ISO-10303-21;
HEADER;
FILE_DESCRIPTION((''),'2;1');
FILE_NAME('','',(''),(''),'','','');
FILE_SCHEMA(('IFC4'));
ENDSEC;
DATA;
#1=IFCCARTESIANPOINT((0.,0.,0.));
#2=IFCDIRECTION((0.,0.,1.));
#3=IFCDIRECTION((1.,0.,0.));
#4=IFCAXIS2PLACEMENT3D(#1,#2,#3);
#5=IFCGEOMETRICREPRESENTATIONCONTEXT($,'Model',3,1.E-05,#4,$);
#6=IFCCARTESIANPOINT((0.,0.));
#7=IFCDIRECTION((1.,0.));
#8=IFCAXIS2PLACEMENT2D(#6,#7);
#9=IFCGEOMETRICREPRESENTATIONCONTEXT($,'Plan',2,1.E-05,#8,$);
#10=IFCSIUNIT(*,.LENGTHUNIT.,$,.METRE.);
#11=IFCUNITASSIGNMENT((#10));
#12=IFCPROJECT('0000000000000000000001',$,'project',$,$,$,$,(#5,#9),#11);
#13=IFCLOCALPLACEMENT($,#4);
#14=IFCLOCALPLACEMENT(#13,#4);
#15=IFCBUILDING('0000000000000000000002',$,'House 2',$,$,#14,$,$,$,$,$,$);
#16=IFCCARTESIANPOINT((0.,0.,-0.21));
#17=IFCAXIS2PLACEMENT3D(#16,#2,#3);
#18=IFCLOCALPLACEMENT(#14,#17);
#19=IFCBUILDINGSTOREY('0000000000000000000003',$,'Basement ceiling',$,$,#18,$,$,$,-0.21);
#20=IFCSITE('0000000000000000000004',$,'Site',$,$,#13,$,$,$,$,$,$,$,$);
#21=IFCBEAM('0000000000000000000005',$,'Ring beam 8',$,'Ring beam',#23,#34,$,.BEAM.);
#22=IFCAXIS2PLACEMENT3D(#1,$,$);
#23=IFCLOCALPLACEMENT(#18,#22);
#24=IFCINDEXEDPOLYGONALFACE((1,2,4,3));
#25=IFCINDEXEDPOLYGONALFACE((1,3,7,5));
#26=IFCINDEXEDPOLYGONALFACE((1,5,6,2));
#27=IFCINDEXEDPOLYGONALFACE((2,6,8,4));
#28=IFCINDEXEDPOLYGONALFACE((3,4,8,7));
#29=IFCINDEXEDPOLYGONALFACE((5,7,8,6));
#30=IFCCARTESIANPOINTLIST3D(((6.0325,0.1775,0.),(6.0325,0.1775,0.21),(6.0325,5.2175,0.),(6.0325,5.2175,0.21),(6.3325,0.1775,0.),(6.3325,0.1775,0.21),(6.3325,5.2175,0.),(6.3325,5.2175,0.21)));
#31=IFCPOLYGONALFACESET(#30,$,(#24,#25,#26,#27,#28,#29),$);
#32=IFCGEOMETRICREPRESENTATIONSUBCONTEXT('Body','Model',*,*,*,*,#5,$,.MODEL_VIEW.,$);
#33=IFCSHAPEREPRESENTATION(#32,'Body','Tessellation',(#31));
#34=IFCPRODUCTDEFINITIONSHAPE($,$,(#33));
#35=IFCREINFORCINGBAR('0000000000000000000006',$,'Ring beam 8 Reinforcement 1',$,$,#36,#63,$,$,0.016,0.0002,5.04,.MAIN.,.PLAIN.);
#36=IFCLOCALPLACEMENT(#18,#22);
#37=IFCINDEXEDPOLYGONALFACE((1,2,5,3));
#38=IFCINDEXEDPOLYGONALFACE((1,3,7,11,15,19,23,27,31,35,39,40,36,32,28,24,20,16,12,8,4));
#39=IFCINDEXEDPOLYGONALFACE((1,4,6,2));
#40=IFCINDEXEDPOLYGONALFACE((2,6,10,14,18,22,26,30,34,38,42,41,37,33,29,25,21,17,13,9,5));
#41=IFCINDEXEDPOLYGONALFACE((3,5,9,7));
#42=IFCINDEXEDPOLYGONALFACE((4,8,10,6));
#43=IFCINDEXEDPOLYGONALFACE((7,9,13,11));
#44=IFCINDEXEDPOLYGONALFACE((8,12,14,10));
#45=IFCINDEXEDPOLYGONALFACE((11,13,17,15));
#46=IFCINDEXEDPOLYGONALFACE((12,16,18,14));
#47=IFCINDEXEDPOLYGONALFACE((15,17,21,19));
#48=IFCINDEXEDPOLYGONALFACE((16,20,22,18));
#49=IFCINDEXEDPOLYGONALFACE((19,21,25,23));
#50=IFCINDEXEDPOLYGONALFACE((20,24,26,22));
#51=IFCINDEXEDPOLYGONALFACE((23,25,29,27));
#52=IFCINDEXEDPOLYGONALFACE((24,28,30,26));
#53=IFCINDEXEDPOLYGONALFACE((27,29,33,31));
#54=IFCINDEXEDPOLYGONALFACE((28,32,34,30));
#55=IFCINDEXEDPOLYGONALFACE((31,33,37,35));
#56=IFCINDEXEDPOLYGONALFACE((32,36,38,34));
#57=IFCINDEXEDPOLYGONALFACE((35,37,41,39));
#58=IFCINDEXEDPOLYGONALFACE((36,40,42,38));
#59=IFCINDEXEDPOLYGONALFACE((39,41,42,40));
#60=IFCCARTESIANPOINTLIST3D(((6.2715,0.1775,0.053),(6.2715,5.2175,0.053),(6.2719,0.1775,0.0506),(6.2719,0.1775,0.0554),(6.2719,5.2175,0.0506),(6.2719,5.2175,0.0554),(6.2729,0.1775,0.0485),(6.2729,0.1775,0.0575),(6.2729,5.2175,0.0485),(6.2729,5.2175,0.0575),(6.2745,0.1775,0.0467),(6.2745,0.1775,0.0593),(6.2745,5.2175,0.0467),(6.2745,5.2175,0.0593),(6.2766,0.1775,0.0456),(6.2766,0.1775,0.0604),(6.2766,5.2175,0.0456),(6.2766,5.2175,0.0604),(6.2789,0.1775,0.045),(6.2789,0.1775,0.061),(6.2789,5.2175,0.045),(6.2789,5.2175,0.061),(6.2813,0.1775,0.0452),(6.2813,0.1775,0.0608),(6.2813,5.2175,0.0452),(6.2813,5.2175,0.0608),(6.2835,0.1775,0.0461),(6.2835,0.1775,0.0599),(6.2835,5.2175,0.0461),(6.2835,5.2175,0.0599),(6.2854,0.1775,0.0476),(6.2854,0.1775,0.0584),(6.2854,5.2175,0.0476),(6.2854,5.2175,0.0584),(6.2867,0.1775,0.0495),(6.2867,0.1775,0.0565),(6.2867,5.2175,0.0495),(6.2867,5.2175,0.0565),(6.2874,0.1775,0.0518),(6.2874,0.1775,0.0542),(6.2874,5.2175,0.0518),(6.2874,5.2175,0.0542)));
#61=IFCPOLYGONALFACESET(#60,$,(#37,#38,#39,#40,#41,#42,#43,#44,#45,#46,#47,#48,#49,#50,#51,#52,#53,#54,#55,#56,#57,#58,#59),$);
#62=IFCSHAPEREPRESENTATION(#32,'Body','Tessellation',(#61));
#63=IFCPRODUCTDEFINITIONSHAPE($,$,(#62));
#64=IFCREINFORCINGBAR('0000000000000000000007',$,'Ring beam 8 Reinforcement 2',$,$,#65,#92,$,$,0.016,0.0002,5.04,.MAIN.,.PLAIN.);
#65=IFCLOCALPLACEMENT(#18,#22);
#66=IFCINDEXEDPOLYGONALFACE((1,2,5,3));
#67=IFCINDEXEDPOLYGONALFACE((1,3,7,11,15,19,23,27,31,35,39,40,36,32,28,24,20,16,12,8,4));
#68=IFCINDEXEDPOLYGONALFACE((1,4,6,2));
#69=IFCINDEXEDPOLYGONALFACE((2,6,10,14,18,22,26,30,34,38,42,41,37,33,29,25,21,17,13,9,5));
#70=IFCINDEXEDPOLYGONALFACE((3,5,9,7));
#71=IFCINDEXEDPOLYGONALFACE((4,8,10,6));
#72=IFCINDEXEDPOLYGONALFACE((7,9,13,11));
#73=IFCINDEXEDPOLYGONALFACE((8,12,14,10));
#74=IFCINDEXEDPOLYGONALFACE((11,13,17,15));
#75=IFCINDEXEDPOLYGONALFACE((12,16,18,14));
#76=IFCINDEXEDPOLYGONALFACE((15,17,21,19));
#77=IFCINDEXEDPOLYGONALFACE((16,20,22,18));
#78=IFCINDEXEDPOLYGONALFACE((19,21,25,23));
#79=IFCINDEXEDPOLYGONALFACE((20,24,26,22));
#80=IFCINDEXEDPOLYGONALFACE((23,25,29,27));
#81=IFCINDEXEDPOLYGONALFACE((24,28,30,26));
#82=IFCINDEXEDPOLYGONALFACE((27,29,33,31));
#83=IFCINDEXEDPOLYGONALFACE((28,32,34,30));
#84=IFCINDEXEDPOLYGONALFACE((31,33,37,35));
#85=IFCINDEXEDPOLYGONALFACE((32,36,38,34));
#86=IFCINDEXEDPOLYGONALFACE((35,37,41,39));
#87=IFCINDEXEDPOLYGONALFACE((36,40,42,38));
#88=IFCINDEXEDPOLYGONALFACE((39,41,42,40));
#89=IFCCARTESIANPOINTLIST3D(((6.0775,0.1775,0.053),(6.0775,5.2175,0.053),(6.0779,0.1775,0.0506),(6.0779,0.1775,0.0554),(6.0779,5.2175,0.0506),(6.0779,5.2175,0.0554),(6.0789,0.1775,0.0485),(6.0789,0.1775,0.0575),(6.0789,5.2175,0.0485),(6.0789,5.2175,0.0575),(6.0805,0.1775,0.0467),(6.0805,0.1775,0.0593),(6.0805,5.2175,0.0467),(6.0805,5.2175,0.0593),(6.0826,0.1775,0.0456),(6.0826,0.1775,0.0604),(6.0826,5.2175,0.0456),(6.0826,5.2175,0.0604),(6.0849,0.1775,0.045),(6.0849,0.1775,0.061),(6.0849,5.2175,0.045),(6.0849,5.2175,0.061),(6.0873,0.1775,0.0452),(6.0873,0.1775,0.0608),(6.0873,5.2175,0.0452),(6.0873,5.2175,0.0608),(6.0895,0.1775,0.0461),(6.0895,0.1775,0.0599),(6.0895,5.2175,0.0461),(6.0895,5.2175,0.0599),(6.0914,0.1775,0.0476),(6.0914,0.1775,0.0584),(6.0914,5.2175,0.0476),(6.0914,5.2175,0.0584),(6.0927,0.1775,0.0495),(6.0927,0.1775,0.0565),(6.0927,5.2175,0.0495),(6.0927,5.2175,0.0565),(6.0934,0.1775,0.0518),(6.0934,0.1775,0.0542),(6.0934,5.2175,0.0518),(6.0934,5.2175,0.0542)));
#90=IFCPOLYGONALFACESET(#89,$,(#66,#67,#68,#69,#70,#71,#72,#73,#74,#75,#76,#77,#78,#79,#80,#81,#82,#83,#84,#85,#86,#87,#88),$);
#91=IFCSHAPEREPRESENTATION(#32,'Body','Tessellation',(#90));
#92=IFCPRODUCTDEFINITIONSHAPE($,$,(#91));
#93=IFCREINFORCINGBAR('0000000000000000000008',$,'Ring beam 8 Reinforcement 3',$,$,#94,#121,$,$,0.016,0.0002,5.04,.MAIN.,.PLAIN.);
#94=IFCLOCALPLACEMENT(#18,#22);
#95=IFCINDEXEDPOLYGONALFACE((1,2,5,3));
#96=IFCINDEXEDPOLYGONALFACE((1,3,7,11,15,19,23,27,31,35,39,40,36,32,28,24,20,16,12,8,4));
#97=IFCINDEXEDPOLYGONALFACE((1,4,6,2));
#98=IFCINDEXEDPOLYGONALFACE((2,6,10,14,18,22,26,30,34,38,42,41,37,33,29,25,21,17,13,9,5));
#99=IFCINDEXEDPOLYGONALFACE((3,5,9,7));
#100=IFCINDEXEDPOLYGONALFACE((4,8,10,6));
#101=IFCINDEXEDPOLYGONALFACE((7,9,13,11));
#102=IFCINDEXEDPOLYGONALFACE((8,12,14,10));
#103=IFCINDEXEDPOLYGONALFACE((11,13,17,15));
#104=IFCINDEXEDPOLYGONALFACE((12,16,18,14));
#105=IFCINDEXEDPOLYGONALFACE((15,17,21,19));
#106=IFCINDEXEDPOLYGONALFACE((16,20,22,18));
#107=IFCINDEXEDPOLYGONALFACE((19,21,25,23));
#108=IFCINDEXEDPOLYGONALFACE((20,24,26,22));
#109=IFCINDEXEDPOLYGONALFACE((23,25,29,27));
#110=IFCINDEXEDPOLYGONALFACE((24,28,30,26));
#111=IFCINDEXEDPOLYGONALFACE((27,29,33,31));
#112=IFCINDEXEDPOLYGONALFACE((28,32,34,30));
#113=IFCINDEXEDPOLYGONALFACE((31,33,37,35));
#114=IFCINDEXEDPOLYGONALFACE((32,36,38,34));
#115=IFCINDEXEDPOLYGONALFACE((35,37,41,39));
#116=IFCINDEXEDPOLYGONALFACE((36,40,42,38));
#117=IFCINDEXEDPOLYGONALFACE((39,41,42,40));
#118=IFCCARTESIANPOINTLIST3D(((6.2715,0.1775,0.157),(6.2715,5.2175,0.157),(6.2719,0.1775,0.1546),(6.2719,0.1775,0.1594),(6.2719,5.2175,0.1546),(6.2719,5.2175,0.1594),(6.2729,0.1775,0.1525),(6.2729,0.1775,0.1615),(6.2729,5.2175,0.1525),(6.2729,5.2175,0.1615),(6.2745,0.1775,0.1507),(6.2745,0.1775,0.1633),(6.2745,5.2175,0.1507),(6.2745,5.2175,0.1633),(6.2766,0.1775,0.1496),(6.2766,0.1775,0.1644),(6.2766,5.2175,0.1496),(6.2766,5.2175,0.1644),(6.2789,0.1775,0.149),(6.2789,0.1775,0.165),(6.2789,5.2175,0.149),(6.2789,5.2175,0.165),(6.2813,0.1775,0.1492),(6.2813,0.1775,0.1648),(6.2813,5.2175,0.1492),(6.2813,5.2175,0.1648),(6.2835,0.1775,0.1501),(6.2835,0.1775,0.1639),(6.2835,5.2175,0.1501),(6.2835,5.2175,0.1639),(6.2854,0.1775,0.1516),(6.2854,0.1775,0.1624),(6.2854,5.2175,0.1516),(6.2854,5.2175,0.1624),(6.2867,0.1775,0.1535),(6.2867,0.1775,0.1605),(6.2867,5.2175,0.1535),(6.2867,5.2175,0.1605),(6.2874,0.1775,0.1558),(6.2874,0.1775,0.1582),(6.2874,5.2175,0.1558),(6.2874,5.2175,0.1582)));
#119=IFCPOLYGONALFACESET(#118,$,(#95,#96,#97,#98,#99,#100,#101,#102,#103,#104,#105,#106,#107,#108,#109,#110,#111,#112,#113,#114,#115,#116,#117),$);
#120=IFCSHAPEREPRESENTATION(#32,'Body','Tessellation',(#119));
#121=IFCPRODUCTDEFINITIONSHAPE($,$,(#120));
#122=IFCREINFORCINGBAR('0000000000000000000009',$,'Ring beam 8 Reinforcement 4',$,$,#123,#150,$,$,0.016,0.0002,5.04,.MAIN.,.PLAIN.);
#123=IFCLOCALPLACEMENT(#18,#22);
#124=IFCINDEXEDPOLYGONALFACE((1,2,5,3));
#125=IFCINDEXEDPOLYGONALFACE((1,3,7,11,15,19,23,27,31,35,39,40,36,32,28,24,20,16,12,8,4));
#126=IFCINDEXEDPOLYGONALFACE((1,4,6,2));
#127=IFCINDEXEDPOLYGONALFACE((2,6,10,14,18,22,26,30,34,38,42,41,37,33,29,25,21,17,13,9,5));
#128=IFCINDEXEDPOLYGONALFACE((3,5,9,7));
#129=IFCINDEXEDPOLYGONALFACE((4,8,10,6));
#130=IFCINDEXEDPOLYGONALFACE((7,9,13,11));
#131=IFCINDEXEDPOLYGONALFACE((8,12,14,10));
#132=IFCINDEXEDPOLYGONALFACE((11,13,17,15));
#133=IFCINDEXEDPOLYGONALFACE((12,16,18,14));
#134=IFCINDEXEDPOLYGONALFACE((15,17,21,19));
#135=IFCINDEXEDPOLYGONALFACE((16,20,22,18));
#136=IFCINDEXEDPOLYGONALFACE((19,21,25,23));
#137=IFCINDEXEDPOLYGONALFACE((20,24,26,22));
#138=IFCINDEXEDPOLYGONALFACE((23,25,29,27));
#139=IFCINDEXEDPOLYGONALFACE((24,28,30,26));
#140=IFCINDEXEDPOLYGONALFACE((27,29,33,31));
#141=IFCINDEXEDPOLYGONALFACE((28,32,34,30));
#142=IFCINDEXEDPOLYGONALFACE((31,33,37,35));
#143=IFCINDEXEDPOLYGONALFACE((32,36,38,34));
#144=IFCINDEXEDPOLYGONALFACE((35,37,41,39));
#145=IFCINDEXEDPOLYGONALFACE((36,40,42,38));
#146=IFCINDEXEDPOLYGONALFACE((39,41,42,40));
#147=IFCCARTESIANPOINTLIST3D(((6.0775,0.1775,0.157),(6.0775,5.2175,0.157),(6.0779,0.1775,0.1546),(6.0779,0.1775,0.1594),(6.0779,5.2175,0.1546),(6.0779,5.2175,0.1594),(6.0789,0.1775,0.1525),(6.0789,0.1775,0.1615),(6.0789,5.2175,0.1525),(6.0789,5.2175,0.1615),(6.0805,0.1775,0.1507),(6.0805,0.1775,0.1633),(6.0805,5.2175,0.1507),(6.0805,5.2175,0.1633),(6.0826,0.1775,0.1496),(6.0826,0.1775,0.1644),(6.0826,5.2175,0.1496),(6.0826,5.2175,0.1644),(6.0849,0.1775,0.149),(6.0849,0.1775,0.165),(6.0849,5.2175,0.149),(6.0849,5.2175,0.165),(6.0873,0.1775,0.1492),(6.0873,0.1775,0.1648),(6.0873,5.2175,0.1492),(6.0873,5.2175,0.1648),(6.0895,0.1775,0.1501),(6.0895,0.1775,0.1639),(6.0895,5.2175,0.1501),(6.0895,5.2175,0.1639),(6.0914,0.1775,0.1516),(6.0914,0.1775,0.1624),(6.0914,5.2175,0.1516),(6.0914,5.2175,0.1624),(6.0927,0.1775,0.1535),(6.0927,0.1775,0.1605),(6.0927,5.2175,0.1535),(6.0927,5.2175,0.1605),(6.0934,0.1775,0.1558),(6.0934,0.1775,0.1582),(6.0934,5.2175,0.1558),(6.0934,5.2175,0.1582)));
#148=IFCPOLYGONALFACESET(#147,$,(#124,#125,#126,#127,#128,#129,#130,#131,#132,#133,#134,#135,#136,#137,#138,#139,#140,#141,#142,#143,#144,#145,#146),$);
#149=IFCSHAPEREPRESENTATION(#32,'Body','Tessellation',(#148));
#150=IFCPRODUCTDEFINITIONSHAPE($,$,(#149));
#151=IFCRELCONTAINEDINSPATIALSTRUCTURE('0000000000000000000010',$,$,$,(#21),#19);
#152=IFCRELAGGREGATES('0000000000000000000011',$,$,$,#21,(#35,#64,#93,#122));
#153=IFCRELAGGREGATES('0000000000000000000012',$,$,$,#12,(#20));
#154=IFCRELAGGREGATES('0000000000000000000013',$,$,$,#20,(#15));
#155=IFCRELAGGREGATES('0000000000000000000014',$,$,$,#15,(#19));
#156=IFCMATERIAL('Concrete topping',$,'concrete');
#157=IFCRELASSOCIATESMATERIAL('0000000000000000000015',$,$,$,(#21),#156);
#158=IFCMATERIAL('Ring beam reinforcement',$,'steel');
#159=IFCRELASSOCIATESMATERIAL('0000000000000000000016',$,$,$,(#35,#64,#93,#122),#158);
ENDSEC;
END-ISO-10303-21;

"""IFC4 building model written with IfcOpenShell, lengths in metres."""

from ifc_helpers import new_model, si_unit, frame, origin_with_axes, origin_2d, origin_2d_with_axis, place, context, subcontext, project, spatial, circle_curve, rectangle, outline, extrude, material, element, aggregate, save


model = new_model("IFC4")

# Units and contexts
model_context = context("Model", 3, precision=1e-05, world=origin_with_axes())
plan_context = context("Plan", 2, precision=1e-05, world=origin_2d_with_axis())
body_context = subcontext(model_context, "Body", "Model", "MODEL_VIEW")
ifc_project = project(units=[si_unit("LENGTHUNIT", "METRE")], contexts=[model_context, plan_context])

# Site, building, storey
site_placement = place(None, origin_with_axes())
site = spatial("IfcSite", under=ifc_project, at=site_placement, Name="Site")
building_placement = place(site_placement, origin_with_axes())
building = spatial("IfcBuilding", under=site, at=building_placement, Name="House 2")
storey_placement = place(building_placement, frame((0.0, 0.0, -0.21), z_axis=(0.0, 0.0, 1.0), x_axis=(1.0, 0.0, 0.0)))
storey = spatial("IfcBuildingStorey", under=building, at=storey_placement, Name="Basement ceiling", Elevation=-0.21)

# Beam
ifc_material_1 = material(Name="Concrete topping", Category="concrete")
beam_1_placement = place(storey_placement, frame((6.1825, 0.1775, 0.105), z_axis=(0.0, 0.0, 1.0), x_axis=(0.0, 1.0, 0.0)))
beam_1 = element("IfcBeam", 1, at=beam_1_placement, inside=storey, material=ifc_material_1, Name="Ring beam 8", ObjectType="Ring beam", PredefinedType="BEAM", context=body_context, shape_type="SweptSolid", body=[
    extrude(rectangle(XDim=0.3, YDim=0.21), frame((0.0, 0.0, 0.0), z_axis=(1.0, 0.0, 0.0), x_axis=(0.0, 1.0, 0.0)), (0.0, 0.0, 1.0), 5.04),
])

# Reinforcing bars
ifc_material_2 = material(Name="Ring beam reinforcement", Category="steel")
reinforcing_bar_1_placement = place(beam_1_placement, frame((0.0, -0.097, -0.052), z_axis=(0.0, 0.0, 1.0), x_axis=(1.0, 0.0, 0.0)))
reinforcing_bar_1 = element("IfcReinforcingBar", 2, at=reinforcing_bar_1_placement, material=ifc_material_2, Name="Ring beam 8 Reinforcement 1", BarLength=5.04, BarSurface="PLAIN", CrossSectionArea=0.0002, NominalDiameter=0.016, PredefinedType="MAIN", context=body_context, shape_type="SweptSolid", body=[
    extrude(outline(circle_curve(origin_2d(), 0.008)), frame((0.0, 0.0, 0.0), z_axis=(1.0, 0.0, 0.0), x_axis=(0.0, 1.0, 0.0)), (0.0, 0.0, 1.0), 5.04),
])
reinforcing_bar_2_placement = place(beam_1_placement, frame((0.0, 0.097, -0.052), z_axis=(0.0, 0.0, 1.0), x_axis=(1.0, 0.0, 0.0)))
reinforcing_bar_2 = element("IfcReinforcingBar", 3, at=reinforcing_bar_2_placement, material=ifc_material_2, Name="Ring beam 8 Reinforcement 2", BarLength=5.04, BarSurface="PLAIN", CrossSectionArea=0.0002, NominalDiameter=0.016, PredefinedType="MAIN", context=body_context, shape_type="SweptSolid", body=[
    extrude(outline(circle_curve(origin_2d(), 0.008)), frame((0.0, 0.0, 0.0), z_axis=(1.0, 0.0, 0.0), x_axis=(0.0, 1.0, 0.0)), (0.0, 0.0, 1.0), 5.04),
])
reinforcing_bar_3_placement = place(beam_1_placement, frame((0.0, -0.097, 0.052), z_axis=(0.0, 0.0, 1.0), x_axis=(1.0, 0.0, 0.0)))
reinforcing_bar_3 = element("IfcReinforcingBar", 4, at=reinforcing_bar_3_placement, material=ifc_material_2, Name="Ring beam 8 Reinforcement 3", BarLength=5.04, BarSurface="PLAIN", CrossSectionArea=0.0002, NominalDiameter=0.016, PredefinedType="MAIN", context=body_context, shape_type="SweptSolid", body=[
    extrude(outline(circle_curve(origin_2d(), 0.008)), frame((0.0, 0.0, 0.0), z_axis=(1.0, 0.0, 0.0), x_axis=(0.0, 1.0, 0.0)), (0.0, 0.0, 1.0), 5.04),
])
reinforcing_bar_4_placement = place(beam_1_placement, frame((0.0, 0.097, 0.052), z_axis=(0.0, 0.0, 1.0), x_axis=(1.0, 0.0, 0.0)))
reinforcing_bar_4 = element("IfcReinforcingBar", 5, at=reinforcing_bar_4_placement, material=ifc_material_2, Name="Ring beam 8 Reinforcement 4", BarLength=5.04, BarSurface="PLAIN", CrossSectionArea=0.0002, NominalDiameter=0.016, PredefinedType="MAIN", context=body_context, shape_type="SweptSolid", body=[
    extrude(outline(circle_curve(origin_2d(), 0.008)), frame((0.0, 0.0, 0.0), z_axis=(1.0, 0.0, 0.0), x_axis=(0.0, 1.0, 0.0)), (0.0, 0.0, 1.0), 5.04),
])
aggregate(beam_1, [reinforcing_bar_1, reinforcing_bar_2, reinforcing_bar_3, reinforcing_bar_4])

save(model, "model.ifc")
